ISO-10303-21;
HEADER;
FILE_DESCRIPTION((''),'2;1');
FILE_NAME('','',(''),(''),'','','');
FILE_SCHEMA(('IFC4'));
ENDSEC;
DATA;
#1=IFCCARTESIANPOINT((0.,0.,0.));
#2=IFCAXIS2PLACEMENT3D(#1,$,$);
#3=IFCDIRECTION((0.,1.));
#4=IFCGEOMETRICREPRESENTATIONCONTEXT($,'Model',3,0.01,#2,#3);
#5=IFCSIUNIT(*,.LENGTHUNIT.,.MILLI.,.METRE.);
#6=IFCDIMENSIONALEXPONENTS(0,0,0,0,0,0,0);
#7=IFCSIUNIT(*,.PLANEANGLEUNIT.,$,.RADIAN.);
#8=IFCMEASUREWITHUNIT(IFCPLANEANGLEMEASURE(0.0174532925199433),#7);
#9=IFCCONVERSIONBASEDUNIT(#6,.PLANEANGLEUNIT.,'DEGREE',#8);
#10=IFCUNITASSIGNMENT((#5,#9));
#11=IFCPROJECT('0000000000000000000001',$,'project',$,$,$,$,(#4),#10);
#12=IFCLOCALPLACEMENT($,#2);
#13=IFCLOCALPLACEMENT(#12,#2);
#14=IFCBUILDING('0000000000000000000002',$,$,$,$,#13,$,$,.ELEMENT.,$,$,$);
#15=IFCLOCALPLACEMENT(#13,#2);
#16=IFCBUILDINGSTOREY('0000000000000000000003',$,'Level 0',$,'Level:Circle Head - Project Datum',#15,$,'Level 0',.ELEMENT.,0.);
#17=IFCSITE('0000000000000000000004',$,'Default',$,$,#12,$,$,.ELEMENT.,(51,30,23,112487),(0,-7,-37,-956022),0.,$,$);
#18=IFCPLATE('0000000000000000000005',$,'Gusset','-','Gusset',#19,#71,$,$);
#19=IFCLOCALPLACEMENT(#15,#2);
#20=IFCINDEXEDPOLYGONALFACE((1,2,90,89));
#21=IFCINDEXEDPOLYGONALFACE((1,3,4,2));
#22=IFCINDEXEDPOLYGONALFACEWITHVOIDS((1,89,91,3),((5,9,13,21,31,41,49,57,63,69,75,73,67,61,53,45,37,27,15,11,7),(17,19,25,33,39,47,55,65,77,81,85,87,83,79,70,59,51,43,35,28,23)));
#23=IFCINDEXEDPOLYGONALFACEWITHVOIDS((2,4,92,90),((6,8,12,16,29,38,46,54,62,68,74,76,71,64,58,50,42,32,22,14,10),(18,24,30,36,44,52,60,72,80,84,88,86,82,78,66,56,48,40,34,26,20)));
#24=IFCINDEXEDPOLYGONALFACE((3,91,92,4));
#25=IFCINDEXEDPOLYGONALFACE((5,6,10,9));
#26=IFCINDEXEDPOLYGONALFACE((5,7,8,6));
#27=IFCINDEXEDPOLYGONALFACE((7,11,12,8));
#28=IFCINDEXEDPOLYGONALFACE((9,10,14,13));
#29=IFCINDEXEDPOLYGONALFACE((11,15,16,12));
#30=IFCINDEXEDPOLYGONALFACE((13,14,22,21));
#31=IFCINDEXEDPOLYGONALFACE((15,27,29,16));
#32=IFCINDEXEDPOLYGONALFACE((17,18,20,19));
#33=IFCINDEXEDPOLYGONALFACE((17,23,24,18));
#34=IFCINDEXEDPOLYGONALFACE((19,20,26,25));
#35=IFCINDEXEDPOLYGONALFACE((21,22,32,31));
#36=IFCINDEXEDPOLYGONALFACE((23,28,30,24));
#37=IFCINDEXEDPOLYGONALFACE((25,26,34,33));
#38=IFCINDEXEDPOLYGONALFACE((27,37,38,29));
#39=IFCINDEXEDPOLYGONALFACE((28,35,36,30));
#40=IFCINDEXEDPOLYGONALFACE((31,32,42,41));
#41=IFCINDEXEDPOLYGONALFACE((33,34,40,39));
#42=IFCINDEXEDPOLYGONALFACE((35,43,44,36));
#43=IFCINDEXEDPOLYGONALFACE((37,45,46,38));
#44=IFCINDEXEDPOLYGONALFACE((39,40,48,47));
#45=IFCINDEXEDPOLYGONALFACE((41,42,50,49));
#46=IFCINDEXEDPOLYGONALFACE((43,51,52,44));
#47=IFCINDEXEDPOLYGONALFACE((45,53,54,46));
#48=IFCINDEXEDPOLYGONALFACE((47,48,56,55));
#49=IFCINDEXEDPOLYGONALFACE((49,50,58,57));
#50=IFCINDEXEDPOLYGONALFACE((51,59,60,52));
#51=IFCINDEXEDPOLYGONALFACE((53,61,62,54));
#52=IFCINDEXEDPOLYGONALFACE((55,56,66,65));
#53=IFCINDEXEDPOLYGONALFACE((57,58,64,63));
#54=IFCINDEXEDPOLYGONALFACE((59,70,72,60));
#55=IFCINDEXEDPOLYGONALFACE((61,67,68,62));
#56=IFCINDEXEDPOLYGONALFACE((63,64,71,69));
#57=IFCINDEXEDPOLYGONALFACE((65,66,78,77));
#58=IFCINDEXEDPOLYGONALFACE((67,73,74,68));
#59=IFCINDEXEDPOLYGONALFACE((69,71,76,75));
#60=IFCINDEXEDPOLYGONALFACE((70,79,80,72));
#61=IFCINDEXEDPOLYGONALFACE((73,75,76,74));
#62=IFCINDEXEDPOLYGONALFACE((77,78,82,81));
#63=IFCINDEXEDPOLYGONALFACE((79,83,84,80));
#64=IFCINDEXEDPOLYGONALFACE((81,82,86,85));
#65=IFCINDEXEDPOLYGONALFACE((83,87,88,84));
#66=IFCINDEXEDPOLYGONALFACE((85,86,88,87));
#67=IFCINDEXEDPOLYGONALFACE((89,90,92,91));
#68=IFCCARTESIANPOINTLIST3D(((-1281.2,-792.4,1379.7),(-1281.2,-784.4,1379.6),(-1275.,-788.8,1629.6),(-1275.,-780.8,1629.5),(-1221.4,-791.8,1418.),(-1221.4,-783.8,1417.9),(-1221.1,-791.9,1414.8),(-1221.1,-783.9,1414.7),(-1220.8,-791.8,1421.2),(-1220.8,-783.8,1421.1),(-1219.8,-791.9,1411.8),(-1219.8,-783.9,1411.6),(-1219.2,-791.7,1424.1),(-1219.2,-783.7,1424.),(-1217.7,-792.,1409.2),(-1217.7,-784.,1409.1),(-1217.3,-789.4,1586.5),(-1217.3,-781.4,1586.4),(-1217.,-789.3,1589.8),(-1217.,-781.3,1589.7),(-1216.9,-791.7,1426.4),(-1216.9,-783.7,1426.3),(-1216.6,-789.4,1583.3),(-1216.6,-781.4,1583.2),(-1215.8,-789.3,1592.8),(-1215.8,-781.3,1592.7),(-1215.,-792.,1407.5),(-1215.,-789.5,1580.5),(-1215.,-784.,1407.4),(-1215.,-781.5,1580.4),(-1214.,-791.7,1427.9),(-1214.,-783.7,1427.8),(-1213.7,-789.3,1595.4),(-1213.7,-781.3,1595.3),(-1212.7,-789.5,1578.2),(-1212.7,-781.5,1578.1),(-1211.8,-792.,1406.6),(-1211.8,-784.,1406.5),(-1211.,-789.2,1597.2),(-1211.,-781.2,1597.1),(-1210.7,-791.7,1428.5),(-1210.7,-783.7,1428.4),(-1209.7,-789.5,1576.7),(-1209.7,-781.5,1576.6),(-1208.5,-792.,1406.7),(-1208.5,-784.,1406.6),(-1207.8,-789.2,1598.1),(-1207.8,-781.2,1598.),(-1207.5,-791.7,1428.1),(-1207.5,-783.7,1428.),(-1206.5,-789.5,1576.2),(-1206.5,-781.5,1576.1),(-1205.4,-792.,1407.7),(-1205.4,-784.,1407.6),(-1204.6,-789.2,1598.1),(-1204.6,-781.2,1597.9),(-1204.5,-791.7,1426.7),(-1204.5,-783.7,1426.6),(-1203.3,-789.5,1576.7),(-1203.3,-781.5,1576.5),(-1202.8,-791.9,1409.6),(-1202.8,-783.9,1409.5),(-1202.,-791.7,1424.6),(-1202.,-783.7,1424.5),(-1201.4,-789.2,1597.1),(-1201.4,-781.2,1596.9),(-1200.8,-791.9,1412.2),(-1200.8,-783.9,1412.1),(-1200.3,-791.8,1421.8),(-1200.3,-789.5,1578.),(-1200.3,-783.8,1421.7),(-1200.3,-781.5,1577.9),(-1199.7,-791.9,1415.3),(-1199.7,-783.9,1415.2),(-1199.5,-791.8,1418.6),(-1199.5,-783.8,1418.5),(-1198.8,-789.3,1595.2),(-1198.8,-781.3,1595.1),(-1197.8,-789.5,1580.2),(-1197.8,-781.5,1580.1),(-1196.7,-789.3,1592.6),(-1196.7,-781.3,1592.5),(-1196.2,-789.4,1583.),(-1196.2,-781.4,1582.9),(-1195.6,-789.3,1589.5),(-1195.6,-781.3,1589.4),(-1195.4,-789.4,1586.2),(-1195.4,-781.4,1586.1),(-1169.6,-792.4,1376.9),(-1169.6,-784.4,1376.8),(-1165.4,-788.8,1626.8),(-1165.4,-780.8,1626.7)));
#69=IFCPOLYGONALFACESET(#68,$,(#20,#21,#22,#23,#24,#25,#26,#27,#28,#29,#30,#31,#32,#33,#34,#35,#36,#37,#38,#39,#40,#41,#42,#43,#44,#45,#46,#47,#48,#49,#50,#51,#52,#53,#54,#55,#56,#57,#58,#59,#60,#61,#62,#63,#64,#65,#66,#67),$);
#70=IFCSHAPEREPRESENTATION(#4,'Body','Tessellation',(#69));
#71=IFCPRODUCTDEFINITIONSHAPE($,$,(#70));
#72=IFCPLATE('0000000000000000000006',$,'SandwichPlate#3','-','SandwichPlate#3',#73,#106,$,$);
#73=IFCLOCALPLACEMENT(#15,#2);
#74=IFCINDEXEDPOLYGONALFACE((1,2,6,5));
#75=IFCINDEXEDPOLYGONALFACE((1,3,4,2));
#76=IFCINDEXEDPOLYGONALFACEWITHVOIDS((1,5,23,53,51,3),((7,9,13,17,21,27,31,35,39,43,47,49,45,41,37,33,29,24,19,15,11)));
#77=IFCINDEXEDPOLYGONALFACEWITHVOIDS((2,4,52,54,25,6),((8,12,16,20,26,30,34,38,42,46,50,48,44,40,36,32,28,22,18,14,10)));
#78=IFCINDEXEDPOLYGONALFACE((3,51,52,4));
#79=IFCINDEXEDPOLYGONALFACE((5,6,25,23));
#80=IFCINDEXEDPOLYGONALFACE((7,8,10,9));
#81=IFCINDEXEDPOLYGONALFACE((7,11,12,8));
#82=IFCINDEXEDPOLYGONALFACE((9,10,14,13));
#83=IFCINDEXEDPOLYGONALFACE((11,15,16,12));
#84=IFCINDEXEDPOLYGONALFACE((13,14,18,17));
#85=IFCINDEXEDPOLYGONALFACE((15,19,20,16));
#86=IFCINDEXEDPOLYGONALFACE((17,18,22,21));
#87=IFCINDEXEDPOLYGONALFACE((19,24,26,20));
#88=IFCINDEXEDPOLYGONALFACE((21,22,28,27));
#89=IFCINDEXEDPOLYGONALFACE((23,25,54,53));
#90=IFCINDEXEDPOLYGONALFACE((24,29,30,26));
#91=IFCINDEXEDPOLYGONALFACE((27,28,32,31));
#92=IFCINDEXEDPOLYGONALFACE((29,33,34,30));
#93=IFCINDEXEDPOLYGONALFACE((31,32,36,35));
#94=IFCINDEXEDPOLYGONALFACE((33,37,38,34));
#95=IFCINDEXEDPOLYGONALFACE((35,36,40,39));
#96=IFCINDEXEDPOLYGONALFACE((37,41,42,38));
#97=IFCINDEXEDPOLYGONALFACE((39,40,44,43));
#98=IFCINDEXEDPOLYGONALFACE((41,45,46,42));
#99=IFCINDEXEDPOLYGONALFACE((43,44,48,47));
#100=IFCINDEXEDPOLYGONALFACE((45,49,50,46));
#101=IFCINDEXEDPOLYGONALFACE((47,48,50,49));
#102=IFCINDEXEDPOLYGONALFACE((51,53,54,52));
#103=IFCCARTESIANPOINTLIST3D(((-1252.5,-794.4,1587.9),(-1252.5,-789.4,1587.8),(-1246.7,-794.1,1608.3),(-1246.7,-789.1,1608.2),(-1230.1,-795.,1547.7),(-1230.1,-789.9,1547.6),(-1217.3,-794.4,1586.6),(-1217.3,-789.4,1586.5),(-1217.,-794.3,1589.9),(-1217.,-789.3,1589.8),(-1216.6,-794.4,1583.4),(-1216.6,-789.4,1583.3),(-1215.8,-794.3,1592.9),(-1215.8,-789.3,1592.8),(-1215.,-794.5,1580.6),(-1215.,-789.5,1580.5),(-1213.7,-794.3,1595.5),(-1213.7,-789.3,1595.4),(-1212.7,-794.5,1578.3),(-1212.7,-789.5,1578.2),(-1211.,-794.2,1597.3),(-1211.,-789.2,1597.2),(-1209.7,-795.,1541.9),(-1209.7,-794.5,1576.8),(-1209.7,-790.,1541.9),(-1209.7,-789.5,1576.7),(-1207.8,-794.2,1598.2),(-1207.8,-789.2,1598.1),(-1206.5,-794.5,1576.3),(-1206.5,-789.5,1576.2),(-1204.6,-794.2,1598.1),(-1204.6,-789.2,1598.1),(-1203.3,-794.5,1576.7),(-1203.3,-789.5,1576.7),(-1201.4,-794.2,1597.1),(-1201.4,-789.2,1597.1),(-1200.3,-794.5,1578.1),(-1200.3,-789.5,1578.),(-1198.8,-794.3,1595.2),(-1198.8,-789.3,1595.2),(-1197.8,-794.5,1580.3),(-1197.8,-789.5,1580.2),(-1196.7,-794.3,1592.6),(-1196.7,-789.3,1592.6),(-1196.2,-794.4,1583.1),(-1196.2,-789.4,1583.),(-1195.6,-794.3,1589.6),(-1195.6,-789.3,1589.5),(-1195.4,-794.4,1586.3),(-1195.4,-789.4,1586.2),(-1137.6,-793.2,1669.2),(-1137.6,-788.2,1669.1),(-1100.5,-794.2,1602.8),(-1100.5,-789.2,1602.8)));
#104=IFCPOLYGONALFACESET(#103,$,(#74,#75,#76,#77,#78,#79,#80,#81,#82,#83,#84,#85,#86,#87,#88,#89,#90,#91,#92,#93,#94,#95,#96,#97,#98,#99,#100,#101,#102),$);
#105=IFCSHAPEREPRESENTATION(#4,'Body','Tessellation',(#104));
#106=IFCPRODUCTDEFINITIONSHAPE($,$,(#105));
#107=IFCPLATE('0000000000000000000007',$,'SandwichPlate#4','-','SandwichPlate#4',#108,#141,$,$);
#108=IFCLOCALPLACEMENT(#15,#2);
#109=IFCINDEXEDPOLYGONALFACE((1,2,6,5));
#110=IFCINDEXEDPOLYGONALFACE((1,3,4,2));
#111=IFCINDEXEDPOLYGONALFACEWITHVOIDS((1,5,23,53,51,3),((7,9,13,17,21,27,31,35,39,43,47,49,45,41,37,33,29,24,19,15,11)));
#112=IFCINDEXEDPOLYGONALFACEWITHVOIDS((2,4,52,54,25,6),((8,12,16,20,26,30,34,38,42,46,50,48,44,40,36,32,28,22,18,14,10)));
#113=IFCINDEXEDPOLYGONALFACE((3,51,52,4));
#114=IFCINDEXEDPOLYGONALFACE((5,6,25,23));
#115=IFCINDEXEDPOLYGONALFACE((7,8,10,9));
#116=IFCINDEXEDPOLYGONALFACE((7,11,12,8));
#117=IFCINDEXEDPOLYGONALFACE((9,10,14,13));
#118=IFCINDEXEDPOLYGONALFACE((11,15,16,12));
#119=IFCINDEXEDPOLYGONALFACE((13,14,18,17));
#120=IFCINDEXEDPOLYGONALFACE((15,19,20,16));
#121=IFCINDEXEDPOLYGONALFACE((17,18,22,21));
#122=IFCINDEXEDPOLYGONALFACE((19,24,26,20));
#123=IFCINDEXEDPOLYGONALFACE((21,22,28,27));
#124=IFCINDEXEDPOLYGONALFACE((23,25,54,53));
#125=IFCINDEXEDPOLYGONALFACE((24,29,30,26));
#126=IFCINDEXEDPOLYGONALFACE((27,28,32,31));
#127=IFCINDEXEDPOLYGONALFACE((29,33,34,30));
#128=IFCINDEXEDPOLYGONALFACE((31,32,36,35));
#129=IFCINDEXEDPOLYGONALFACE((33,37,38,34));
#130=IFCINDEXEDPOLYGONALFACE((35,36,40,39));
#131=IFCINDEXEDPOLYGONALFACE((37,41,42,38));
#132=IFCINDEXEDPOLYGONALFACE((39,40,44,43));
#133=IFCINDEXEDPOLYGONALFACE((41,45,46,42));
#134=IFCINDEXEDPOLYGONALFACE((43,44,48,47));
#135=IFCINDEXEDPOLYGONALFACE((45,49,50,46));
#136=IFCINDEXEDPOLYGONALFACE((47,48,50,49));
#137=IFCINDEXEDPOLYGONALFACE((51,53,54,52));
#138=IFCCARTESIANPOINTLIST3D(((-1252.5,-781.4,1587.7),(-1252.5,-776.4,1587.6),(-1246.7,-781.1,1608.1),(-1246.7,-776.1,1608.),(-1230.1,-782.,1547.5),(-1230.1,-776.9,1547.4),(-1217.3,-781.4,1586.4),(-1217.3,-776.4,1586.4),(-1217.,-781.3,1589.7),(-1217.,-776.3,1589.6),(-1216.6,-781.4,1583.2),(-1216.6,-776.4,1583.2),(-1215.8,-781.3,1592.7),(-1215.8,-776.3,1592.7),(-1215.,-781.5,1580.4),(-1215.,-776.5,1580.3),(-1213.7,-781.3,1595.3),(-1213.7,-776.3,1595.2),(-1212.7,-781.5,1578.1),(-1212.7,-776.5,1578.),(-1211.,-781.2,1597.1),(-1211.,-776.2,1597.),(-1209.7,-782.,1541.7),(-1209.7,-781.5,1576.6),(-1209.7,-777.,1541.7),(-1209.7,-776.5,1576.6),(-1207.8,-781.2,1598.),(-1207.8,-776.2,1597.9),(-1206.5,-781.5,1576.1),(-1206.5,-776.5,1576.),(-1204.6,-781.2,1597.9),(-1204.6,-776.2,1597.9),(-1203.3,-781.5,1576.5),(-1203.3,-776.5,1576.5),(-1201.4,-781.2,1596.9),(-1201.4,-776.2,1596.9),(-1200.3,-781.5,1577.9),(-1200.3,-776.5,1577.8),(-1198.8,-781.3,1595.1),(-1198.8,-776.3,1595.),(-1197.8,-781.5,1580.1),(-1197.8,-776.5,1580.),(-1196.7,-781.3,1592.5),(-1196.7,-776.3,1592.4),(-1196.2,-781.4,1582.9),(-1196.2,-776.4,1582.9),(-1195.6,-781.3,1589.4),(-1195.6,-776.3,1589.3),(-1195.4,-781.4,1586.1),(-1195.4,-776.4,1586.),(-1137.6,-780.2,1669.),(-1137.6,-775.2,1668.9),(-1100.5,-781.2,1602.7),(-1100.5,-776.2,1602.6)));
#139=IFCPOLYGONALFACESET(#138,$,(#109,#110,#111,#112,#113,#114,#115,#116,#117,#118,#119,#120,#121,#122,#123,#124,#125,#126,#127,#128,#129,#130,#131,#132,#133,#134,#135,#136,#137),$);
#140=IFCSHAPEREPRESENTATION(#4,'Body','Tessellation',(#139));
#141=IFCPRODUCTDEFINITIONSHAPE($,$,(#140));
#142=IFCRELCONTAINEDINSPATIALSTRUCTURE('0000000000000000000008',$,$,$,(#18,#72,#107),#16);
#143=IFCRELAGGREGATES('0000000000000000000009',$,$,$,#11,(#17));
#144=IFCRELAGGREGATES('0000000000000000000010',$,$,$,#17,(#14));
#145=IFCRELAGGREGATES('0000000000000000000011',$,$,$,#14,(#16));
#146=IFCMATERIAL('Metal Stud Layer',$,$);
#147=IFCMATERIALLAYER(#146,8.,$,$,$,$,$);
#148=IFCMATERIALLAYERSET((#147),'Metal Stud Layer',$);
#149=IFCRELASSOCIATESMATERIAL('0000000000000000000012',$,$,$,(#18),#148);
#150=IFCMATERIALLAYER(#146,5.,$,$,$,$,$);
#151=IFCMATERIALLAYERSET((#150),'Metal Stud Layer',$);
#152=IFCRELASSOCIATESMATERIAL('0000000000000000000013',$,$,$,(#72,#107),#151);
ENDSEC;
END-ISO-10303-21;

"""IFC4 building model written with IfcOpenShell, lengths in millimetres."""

from ifc_helpers import new_model, entity, si_unit, converted_unit, direction, frame, origin, origin_with_axes, origin_2d_with_axis, place, context, project, spatial, polyline, circle, outline, extrude, material, layer, layer_set, element, save


model = new_model("IFC4")

# Units and contexts
model_context_1 = context("Model", 3, precision=0.01, world=origin(), true_north=direction((0.0, 1.0)))
ifc_project = project(units=[si_unit("LENGTHUNIT", "METRE", prefix="MILLI"), converted_unit("PLANEANGLEUNIT", "DEGREE", entity("IfcPlaneAngleMeasure", 0.0174532925199433), si_unit("PLANEANGLEUNIT", "RADIAN"), dimensions=[0, 0, 0, 0, 0, 0, 0])], contexts=[model_context_1])

# Site, building, storey
site_placement = place(None, origin())
site = spatial("IfcSite", under=ifc_project, at=site_placement, Name="Default", CompositionType="ELEMENT", RefLatitude=(51, 30, 23, 112487), RefLongitude=(0, -7, -37, -956022), RefElevation=0.0)
building_placement = place(site_placement, origin())
building = spatial("IfcBuilding", under=site, at=building_placement, CompositionType="ELEMENT")
storey_placement = place(building_placement, origin())
storey = spatial("IfcBuildingStorey", under=building, at=storey_placement, Name="Level 0", ObjectType="Level:Circle Head - Project Datum", LongName="Level 0", CompositionType="ELEMENT", Elevation=0.0)

# Plates, openings
ifc_material_1 = material(Name="Metal Stud Layer")
ifc_layer_1 = layer(ifc_material_1, 8.0)
ifc_layer_set_1 = layer_set([ifc_layer_1], Name="Metal Stud Layer")
plate_1_placement = place(storey_placement, frame((-1272.8, -780.8, 1628.9), z_axis=(0.0, -0.999896, 0.014432), x_axis=(-0.02499, -0.014428, -0.999584)))
plate_1 = element("IfcPlate", 1, at=plate_1_placement, inside=storey, material=ifc_layer_set_1, Name="Gusset", Description="-", ObjectType="Gusset", context=model_context_1, shape_type="SweptSolid", body=[
    extrude(outline(polyline([(-0.5, -2.2), (249.5, -2.2), (249.5, 109.5), (-0.5, 107.4), (-0.5, -2.2)])), origin_with_axes(), (0.0, 0.0, 1.0), 8.0),
])
opening_1_placement = place(plate_1_placement, frame((40.2, 67.5, 8.5), z_axis=(0.0, 0.0, -1.0), x_axis=(-0.509073, 0.860723, 0.0)))
element("IfcOpeningElement", 2, at=opening_1_placement, cuts=plate_1, ObjectType="Opening", context=model_context_1, shape_type="SweptSolid", body=[
    extrude(circle(Radius=11.0, at=origin_2d_with_axis()), origin(), (0.0, 0.0, 1.0), 9.0),
])
opening_2_placement = place(plate_1_placement, frame((209.9, 67.6, 8.5), z_axis=(0.0, 0.0, -1.0), x_axis=(0.455108, 0.890436, 0.0)))
element("IfcOpeningElement", 3, at=opening_2_placement, cuts=plate_1, ObjectType="Opening", context=model_context_1, shape_type="SweptSolid", body=[
    extrude(circle(Radius=11.0, at=origin_2d_with_axis()), origin(), (0.0, 0.0, 1.0), 9.0),
])
ifc_layer_2 = layer(ifc_material_1, 5.0)
ifc_layer_set_2 = layer_set([ifc_layer_2], Name="Metal Stud Layer")
plate_2_placement = place(storey_placement, frame((-1222.8, -795.1, 1534.6), z_axis=(0.0, 0.999896, -0.014432), x_axis=(-0.487405, 0.012602, 0.873085)))
plate_2 = element("IfcPlate", 4, at=plate_2_placement, inside=storey, material=ifc_layer_set_2, Name="SandwichPlate#3", Description="-", ObjectType="SandwichPlate#3", context=model_context_1, shape_type="SweptSolid", body=[
    extrude(outline(polyline([(0.0, 0.0), (76.0, 0.0), (76.0, 140.0), (0.0, 140.0), (0.0, 0.0)])), origin_with_axes(), (0.0, 0.0, 1.0), 5.0),
])
opening_3_placement = place(plate_2_placement, frame((0.0, 0.0, 0.0), z_axis=(0.0, 0.0, 1.0), x_axis=(1.0, 0.0, 0.0)))
element("IfcOpeningElement", 5, at=opening_3_placement, cuts=plate_2, ObjectType="Opening", context=model_context_1, shape_type="SweptSolid", body=[
    extrude(outline(polyline([(0.0, 0.0), (15.0, 0.0), (0.0, 15.0), (0.0, 0.0)])), origin(), (0.0, 0.0, 1.0), 5.0),
])
opening_4_placement = place(plate_2_placement, frame((0.0, 0.0, 0.0), z_axis=(0.0, 0.0, 1.0), x_axis=(1.0, 0.0, 0.0)))
element("IfcOpeningElement", 6, at=opening_4_placement, cuts=plate_2, ObjectType="Opening", context=model_context_1, shape_type="SweptSolid", body=[
    extrude(outline(polyline([(76.0, 0.0), (76.0, 15.0), (61.0, 0.0), (76.0, 0.0)])), origin(), (0.0, 0.0, 1.0), 5.0),
])
opening_5_placement = place(plate_2_placement, frame((38.0, 40.0, -0.5), z_axis=(0.0, 0.0, 1.0), x_axis=(0.0, 1.0, 0.0)))
element("IfcOpeningElement", 7, at=opening_5_placement, cuts=plate_2, ObjectType="Opening", context=model_context_1, shape_type="SweptSolid", body=[
    extrude(circle(Radius=11.0, at=origin_2d_with_axis()), origin(), (0.0, 0.0, 1.0), 6.0),
])
plate_3_placement = place(storey_placement, frame((-1222.8, -782.1, 1534.4), z_axis=(0.0, 0.999896, -0.014432), x_axis=(-0.487405, 0.012602, 0.873085)))
plate_3 = element("IfcPlate", 8, at=plate_3_placement, inside=storey, material=ifc_layer_set_2, Name="SandwichPlate#4", Description="-", ObjectType="SandwichPlate#4", context=model_context_1, shape_type="SweptSolid", body=[
    extrude(outline(polyline([(0.0, 0.0), (76.0, 0.0), (76.0, 140.0), (0.0, 140.0), (0.0, 0.0)])), origin_with_axes(), (0.0, 0.0, 1.0), 5.0),
])
opening_6_placement = place(plate_3_placement, frame((0.0, 0.0, 0.0), z_axis=(0.0, 0.0, 1.0), x_axis=(1.0, 0.0, 0.0)))
element("IfcOpeningElement", 9, at=opening_6_placement, cuts=plate_3, ObjectType="Opening", context=model_context_1, shape_type="SweptSolid", body=[
    extrude(outline(polyline([(0.0, 0.0), (15.0, 0.0), (0.0, 15.0), (0.0, 0.0)])), origin(), (0.0, 0.0, 1.0), 5.0),
])
opening_7_placement = place(plate_3_placement, frame((0.0, 0.0, 0.0), z_axis=(0.0, 0.0, 1.0), x_axis=(1.0, 0.0, 0.0)))
element("IfcOpeningElement", 10, at=opening_7_placement, cuts=plate_3, ObjectType="Opening", context=model_context_1, shape_type="SweptSolid", body=[
    extrude(outline(polyline([(76.0, 0.0), (76.0, 15.0), (61.0, 0.0), (76.0, 0.0)])), origin(), (0.0, 0.0, 1.0), 5.0),
])
opening_8_placement = place(plate_3_placement, frame((38.0, 40.0, -0.5), z_axis=(0.0, 0.0, 1.0), x_axis=(0.0, 1.0, 0.0)))
element("IfcOpeningElement", 11, at=opening_8_placement, cuts=plate_3, ObjectType="Opening", context=model_context_1, shape_type="SweptSolid", body=[
    extrude(circle(Radius=11.0, at=origin_2d_with_axis()), origin(), (0.0, 0.0, 1.0), 6.0),
])

save(model, "model.ifc")
